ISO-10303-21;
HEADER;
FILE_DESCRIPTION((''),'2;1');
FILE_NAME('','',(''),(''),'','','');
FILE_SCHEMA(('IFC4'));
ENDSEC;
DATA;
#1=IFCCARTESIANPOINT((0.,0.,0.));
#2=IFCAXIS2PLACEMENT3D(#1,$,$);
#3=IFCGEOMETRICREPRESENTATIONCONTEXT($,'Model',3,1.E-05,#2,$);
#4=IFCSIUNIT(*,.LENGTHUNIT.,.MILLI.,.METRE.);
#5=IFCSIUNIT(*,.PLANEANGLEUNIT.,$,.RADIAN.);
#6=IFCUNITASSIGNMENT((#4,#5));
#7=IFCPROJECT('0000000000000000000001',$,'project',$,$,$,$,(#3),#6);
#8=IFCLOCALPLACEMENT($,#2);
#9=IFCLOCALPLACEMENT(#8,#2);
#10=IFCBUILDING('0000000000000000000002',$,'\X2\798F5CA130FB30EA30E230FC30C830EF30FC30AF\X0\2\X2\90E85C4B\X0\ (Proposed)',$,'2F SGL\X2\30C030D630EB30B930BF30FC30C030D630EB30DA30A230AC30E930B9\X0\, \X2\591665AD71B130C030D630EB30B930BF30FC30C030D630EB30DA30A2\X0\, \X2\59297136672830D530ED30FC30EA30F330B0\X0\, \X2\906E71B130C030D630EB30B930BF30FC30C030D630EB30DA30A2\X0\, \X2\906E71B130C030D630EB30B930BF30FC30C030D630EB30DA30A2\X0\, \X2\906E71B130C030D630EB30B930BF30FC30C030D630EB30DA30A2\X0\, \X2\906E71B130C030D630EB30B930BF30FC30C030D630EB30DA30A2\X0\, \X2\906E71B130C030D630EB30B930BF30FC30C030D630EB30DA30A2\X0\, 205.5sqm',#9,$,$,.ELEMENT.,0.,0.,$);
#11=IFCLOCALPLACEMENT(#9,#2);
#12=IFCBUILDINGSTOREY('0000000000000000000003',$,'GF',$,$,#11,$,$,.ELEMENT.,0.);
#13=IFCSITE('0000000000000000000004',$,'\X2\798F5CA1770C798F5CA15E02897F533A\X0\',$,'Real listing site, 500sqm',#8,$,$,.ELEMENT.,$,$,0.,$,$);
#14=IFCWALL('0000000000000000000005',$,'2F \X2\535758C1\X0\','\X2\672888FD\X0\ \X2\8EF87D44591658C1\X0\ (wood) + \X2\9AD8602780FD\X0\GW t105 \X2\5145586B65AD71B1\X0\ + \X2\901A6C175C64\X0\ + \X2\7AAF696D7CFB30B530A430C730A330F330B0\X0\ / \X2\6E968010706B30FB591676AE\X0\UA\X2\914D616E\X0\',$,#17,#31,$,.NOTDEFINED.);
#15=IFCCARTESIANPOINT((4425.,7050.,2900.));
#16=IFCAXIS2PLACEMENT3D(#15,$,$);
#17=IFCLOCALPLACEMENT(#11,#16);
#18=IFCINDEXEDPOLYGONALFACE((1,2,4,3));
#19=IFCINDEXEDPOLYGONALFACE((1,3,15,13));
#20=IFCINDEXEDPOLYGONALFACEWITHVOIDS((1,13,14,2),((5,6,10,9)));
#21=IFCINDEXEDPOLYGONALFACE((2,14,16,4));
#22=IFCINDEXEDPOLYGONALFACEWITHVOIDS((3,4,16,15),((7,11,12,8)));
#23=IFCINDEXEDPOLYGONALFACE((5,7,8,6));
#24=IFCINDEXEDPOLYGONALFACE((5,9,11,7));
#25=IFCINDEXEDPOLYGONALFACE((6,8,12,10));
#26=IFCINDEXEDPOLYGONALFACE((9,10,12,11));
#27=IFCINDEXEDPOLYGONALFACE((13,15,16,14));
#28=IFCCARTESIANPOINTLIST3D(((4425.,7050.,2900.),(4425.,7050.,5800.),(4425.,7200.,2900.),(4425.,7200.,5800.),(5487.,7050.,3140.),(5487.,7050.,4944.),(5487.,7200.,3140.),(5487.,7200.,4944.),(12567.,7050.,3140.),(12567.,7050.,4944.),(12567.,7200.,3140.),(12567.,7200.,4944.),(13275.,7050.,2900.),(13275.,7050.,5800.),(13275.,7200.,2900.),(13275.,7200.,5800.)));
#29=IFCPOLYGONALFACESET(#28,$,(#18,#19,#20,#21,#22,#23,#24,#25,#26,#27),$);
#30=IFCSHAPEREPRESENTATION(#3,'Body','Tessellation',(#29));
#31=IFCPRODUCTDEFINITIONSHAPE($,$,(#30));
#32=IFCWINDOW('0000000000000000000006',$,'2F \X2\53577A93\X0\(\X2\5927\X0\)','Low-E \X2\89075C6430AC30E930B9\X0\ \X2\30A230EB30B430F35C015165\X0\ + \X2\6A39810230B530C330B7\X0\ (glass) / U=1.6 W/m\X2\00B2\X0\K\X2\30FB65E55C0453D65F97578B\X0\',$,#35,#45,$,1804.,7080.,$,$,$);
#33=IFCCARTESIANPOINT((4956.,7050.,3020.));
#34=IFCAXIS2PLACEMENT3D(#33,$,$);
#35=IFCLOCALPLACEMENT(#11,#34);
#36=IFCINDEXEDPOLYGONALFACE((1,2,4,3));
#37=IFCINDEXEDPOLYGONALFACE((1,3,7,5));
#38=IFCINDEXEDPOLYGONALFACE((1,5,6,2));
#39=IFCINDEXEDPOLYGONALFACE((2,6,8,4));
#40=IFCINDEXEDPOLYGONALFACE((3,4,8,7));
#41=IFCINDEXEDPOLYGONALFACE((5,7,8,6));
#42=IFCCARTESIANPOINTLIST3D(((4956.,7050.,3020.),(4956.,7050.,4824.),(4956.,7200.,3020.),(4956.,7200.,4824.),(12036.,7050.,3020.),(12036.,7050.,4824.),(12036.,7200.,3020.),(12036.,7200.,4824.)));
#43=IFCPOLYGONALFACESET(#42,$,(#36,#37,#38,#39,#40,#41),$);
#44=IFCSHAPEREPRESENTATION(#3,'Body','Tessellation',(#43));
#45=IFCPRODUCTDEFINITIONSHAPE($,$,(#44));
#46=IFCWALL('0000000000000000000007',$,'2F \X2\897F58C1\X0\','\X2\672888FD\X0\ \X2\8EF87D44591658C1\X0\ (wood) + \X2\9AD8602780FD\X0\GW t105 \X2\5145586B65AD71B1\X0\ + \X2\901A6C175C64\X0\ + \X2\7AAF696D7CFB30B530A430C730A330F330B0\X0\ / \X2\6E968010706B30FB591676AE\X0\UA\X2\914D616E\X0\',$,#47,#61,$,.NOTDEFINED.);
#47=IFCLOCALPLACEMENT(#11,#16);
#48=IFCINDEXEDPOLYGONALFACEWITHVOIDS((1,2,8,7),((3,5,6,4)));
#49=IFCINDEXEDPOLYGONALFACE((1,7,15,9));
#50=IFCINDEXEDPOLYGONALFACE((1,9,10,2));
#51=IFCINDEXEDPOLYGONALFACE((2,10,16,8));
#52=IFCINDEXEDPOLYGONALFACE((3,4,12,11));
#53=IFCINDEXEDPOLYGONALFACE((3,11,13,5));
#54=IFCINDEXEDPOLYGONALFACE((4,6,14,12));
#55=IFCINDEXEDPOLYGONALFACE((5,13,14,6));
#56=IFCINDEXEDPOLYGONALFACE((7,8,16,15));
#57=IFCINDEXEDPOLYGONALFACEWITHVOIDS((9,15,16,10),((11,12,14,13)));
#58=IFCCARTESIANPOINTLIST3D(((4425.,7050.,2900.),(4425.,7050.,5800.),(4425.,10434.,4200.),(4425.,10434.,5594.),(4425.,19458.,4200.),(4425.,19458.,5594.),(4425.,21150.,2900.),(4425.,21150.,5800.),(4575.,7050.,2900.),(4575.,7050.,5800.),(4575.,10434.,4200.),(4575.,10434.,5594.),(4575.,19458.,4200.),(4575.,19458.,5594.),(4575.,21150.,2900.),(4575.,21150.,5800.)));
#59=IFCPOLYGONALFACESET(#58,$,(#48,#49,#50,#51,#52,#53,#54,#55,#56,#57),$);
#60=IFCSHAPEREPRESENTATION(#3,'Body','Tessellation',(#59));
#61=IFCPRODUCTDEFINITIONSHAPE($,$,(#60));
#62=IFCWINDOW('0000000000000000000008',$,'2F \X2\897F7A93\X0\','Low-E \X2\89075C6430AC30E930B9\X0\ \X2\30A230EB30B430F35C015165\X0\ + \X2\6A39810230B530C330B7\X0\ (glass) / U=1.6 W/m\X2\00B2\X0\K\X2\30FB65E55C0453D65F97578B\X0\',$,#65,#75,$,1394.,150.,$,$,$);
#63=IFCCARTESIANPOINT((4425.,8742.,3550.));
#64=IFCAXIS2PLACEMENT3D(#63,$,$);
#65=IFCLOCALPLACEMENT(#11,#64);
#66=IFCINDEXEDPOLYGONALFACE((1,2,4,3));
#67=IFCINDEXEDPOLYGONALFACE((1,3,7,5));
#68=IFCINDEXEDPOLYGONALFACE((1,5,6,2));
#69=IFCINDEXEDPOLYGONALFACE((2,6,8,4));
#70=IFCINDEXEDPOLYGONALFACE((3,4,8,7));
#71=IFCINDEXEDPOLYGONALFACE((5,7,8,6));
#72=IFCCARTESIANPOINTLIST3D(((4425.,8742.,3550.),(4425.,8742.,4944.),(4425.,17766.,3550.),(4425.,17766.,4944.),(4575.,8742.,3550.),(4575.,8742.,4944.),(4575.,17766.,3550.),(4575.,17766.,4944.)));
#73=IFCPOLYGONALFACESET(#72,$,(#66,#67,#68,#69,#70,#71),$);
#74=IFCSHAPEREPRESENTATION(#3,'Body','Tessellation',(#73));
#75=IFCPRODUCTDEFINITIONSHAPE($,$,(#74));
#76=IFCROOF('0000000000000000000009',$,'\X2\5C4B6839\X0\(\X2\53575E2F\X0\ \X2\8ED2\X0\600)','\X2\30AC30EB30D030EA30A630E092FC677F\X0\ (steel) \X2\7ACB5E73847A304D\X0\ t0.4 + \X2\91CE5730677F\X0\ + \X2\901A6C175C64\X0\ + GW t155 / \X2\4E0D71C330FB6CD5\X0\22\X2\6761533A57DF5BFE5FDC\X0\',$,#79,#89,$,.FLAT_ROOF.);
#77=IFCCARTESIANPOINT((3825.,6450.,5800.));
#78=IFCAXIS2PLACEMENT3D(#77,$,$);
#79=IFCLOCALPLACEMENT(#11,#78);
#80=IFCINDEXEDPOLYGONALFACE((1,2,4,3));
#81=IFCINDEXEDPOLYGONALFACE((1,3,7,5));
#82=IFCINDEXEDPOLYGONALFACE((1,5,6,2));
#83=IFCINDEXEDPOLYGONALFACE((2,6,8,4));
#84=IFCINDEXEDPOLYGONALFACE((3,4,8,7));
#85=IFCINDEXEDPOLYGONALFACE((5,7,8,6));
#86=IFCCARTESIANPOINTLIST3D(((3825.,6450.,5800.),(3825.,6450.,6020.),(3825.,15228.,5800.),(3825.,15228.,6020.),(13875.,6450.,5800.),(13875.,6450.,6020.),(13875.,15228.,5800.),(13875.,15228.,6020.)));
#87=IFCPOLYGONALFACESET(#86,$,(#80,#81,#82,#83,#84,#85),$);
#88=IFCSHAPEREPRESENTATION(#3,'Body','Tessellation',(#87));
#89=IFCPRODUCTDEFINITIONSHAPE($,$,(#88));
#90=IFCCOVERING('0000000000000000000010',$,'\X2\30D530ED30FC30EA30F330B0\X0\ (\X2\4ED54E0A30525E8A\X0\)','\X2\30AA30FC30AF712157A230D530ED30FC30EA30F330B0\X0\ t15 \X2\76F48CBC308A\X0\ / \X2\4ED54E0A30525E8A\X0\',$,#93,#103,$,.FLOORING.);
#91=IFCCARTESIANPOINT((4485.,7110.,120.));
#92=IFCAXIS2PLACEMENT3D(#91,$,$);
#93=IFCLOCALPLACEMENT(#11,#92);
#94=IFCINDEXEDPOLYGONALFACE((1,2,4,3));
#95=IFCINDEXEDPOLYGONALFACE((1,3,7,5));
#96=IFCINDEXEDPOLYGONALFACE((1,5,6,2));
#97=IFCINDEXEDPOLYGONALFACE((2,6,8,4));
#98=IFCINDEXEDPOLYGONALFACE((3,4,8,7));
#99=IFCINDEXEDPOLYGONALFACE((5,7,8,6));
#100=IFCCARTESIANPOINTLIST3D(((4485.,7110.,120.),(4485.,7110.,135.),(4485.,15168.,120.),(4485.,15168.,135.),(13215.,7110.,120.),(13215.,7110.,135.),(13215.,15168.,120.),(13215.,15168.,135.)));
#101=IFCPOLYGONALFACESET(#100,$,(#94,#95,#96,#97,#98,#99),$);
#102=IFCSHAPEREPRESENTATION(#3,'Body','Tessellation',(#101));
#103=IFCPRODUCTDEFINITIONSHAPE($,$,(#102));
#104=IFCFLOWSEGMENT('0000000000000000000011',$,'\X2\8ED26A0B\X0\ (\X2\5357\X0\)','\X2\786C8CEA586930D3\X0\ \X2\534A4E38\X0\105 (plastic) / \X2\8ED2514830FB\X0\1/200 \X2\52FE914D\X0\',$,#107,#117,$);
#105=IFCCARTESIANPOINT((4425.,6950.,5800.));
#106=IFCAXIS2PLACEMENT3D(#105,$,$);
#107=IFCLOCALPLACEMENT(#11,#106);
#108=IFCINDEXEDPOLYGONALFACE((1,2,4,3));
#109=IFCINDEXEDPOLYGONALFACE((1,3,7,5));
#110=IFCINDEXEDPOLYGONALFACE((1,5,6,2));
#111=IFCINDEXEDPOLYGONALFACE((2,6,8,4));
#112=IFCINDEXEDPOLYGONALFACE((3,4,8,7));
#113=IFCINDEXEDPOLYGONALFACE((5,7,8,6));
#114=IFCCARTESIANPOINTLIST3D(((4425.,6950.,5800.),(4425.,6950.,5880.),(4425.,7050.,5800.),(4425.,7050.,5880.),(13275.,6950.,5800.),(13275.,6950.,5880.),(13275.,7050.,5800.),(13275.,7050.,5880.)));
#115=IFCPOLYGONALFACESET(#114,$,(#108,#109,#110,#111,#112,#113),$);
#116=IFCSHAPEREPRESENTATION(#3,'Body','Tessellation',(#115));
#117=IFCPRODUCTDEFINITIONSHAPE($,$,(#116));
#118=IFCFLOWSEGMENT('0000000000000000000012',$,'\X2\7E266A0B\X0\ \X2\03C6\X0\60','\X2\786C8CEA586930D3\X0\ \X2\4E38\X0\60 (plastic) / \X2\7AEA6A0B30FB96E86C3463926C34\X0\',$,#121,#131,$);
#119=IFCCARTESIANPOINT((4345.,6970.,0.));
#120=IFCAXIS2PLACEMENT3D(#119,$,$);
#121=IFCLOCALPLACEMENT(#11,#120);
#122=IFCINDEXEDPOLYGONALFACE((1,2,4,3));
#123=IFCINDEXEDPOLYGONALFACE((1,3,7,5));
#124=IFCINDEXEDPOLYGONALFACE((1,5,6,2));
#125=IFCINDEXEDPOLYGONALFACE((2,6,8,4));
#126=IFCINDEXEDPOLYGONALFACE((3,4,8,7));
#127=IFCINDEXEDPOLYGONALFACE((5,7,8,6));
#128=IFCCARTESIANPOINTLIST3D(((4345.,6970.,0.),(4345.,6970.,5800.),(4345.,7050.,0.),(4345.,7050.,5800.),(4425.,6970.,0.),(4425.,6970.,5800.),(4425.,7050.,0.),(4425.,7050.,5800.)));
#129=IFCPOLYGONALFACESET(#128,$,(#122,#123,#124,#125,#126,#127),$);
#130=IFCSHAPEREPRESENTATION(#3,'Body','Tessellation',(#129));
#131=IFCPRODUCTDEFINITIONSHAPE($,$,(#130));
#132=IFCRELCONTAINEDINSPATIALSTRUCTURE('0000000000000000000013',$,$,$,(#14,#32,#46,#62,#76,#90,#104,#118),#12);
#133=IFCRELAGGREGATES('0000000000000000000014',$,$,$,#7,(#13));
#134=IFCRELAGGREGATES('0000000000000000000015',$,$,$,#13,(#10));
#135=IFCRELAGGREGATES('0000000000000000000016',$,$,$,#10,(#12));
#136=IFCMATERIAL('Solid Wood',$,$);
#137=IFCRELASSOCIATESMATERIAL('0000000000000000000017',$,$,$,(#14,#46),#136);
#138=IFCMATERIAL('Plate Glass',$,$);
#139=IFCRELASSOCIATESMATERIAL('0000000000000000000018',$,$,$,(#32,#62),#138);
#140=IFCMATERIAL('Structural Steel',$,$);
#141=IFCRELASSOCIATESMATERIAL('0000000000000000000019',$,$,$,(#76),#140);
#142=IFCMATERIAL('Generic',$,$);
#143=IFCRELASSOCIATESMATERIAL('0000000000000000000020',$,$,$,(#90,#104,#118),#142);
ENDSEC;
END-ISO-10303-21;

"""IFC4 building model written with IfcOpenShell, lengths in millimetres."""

from ifc_helpers import new_model, si_unit, frame, frame_2d, origin, place, context, project, spatial, rectangle, extrude, material, element, fill, save


model = new_model("IFC4")

# Units and contexts
model_context = context("Model", 3, precision=1e-05, world=origin())
ifc_project = project(units=[si_unit("LENGTHUNIT", "METRE", prefix="MILLI"), si_unit("PLANEANGLEUNIT", "RADIAN")], contexts=[model_context])

# Site, building, storey
site_placement = place(None, origin())
site = spatial("IfcSite", under=ifc_project, at=site_placement, Name="福岡県福岡市西区", ObjectType="Real listing site, 500sqm", CompositionType="ELEMENT", RefElevation=0.0)
building_placement = place(site_placement, origin())
building = spatial("IfcBuilding", under=site, at=building_placement, Name="福岡・リモートワーク2部屋 (Proposed)", ObjectType="2F SGLダブルスターダブルペアガラス, 外断熱ダブルスターダブルペア, 天然木フローリング, 遮熱ダブルスターダブルペア, 遮熱ダブルスターダブルペア, 遮熱ダブルスターダブルペア, 遮熱ダブルスターダブルペア, 遮熱ダブルスターダブルペア, 205.5sqm", CompositionType="ELEMENT", ElevationOfRefHeight=0.0, ElevationOfTerrain=0.0)
storey_placement = place(building_placement, origin())
storey = spatial("IfcBuildingStorey", under=building, at=storey_placement, Name="GF", CompositionType="ELEMENT", Elevation=0.0)

# Shared definitions
ifc_material_1 = material(Name="Solid Wood")

# Shared definitions
ifc_material_2 = material(Name="Plate Glass")

# Walls, openings, windows
wall_1_placement = place(storey_placement, frame((4425.0, 7050.0, 2900.0)))
wall_1 = element("IfcWall", 1, at=wall_1_placement, inside=storey, material=ifc_material_1, Name="2F 南壁", Description="木製 軸組外壁 (wood) + 高性能GW t105 充填断熱 + 通気層 + 窯業系サイディング / 準耐火・外皮UA配慮", PredefinedType="NOTDEFINED", context=model_context, shape_type="SweptSolid", body=[
    extrude(rectangle(XDim=8850.0, YDim=150.0, at=frame_2d((4425.0, 75.0))), frame((4425.0, 7050.0, 2900.0)), (0.0, 0.0, 1.0), 2900.0),
])
opening_1_placement = place(storey_placement, frame((4956.0, 7050.0, 3020.0)))
opening_1 = element("IfcOpeningElement", 2, at=opening_1_placement, cuts=wall_1, PredefinedType="NOTDEFINED", context=model_context, shape_type="SweptSolid", body=[
    extrude(rectangle(XDim=7080.0, YDim=150.0, at=frame_2d((3540.0, 75.0))), frame((4956.0, 7050.0, 3020.0)), (0.0, 0.0, 1.0), 1804.0),
])
window_1_placement = place(storey_placement, frame((4956.0, 7050.0, 3020.0)))
window_1 = element("IfcWindow", 3, at=window_1_placement, inside=storey, material=ifc_material_2, Name="2F 南窓(大)", Description="Low-E 複層ガラス アルゴン封入 + 樹脂サッシ (glass) / U=1.6 W/m²K・日射取得型", OverallHeight=1804.0, OverallWidth=7080.0, context=model_context, shape_type="SweptSolid", body=[
    extrude(rectangle(XDim=7080.0, YDim=150.0, at=frame_2d((3540.0, 75.0))), frame((4956.0, 7050.0, 3020.0)), (0.0, 0.0, 1.0), 1804.0),
])
fill(opening_1, window_1)
wall_2_placement = place(storey_placement, frame((4425.0, 7050.0, 2900.0)))
wall_2 = element("IfcWall", 4, at=wall_2_placement, inside=storey, material=ifc_material_1, Name="2F 西壁", Description="木製 軸組外壁 (wood) + 高性能GW t105 充填断熱 + 通気層 + 窯業系サイディング / 準耐火・外皮UA配慮", PredefinedType="NOTDEFINED", context=model_context, shape_type="SweptSolid", body=[
    extrude(rectangle(XDim=150.0, YDim=14100.0, at=frame_2d((75.0, 7050.0))), frame((4425.0, 7050.0, 2900.0)), (0.0, 0.0, 1.0), 2900.0),
])
opening_2_placement = place(storey_placement, frame((4425.0, 8742.0, 3550.0)))
opening_2 = element("IfcOpeningElement", 5, at=opening_2_placement, cuts=wall_2, PredefinedType="NOTDEFINED", context=model_context, shape_type="SweptSolid", body=[
    extrude(rectangle(XDim=150.0, YDim=9024.0, at=frame_2d((75.0, 4512.0))), frame((4425.0, 8742.0, 3550.0)), (0.0, 0.0, 1.0), 1394.0),
])
window_2_placement = place(storey_placement, frame((4425.0, 8742.0, 3550.0)))
window_2 = element("IfcWindow", 6, at=window_2_placement, inside=storey, material=ifc_material_2, Name="2F 西窓", Description="Low-E 複層ガラス アルゴン封入 + 樹脂サッシ (glass) / U=1.6 W/m²K・日射取得型", OverallHeight=1394.0, OverallWidth=150.0, context=model_context, shape_type="SweptSolid", body=[
    extrude(rectangle(XDim=150.0, YDim=9024.0, at=frame_2d((75.0, 4512.0))), frame((4425.0, 8742.0, 3550.0)), (0.0, 0.0, 1.0), 1394.0),
])
fill(opening_2, window_2)

# Roof
ifc_material_3 = material(Name="Structural Steel")
for number, where, name in (
    (7, (3825.0, 6450.0, 5800.0), "屋根(南帯 軒600)"),
):
    element("IfcRoof", number, at=place(storey_placement, frame(where)), inside=storey, material=ifc_material_3, Name=name, Description="ガルバリウム鋼板 (steel) 立平葺き t0.4 + 野地板 + 通気層 + GW t155 / 不燃・法22条区域対応", PredefinedType="FLAT_ROOF", context=model_context, shape_type="SweptSolid", body=[
        extrude(rectangle(XDim=10050.0, YDim=8778.0, at=frame_2d((5025.0, 4389.0))), frame((3825.0, 6450.0, 5800.0)), (0.0, 0.0, 1.0), 220.0),
    ])

# Covering
ifc_material_4 = material(Name="Generic")
covering_placement = place(storey_placement, frame((4485.0, 7110.0, 120.0)))
element("IfcCovering", 8, at=covering_placement, inside=storey, material=ifc_material_4, Name="フローリング (仕上げ床)", Description="オーク無垢フローリング t15 直貼り / 仕上げ床", PredefinedType="FLOORING", context=model_context, shape_type="SweptSolid", body=[
    extrude(rectangle(XDim=8730.0, YDim=8058.0, at=frame_2d((4365.0, 4029.0))), frame((4485.0, 7110.0, 120.0)), (0.0, 0.0, 1.0), 15.0),
])

# Flow segments
flow_segment_1_placement = place(storey_placement, frame((4425.0, 6950.0, 5800.0)))
element("IfcFlowSegment", 9, at=flow_segment_1_placement, inside=storey, material=ifc_material_4, Name="軒樋 (南)", Description="硬質塩ビ 半丸105 (plastic) / 軒先・1/200 勾配", context=model_context, shape_type="SweptSolid", body=[
    extrude(rectangle(XDim=8850.0, YDim=100.0, at=frame_2d((4425.0, 50.0))), frame((4425.0, 6950.0, 5800.0)), (0.0, 0.0, 1.0), 80.0),
])
flow_segment_2_placement = place(storey_placement, frame((4345.0, 6970.0, 0.0)))
element("IfcFlowSegment", 10, at=flow_segment_2_placement, inside=storey, material=ifc_material_4, Name="縦樋 φ60", Description="硬質塩ビ 丸60 (plastic) / 竪樋・雨水排水", context=model_context, shape_type="SweptSolid", body=[
    extrude(rectangle(XDim=80.0, YDim=80.0, at=frame_2d((40.0, 40.0))), frame((4345.0, 6970.0, 0.0)), (0.0, 0.0, 1.0), 5800.0),
])

save(model, "model.ifc")
